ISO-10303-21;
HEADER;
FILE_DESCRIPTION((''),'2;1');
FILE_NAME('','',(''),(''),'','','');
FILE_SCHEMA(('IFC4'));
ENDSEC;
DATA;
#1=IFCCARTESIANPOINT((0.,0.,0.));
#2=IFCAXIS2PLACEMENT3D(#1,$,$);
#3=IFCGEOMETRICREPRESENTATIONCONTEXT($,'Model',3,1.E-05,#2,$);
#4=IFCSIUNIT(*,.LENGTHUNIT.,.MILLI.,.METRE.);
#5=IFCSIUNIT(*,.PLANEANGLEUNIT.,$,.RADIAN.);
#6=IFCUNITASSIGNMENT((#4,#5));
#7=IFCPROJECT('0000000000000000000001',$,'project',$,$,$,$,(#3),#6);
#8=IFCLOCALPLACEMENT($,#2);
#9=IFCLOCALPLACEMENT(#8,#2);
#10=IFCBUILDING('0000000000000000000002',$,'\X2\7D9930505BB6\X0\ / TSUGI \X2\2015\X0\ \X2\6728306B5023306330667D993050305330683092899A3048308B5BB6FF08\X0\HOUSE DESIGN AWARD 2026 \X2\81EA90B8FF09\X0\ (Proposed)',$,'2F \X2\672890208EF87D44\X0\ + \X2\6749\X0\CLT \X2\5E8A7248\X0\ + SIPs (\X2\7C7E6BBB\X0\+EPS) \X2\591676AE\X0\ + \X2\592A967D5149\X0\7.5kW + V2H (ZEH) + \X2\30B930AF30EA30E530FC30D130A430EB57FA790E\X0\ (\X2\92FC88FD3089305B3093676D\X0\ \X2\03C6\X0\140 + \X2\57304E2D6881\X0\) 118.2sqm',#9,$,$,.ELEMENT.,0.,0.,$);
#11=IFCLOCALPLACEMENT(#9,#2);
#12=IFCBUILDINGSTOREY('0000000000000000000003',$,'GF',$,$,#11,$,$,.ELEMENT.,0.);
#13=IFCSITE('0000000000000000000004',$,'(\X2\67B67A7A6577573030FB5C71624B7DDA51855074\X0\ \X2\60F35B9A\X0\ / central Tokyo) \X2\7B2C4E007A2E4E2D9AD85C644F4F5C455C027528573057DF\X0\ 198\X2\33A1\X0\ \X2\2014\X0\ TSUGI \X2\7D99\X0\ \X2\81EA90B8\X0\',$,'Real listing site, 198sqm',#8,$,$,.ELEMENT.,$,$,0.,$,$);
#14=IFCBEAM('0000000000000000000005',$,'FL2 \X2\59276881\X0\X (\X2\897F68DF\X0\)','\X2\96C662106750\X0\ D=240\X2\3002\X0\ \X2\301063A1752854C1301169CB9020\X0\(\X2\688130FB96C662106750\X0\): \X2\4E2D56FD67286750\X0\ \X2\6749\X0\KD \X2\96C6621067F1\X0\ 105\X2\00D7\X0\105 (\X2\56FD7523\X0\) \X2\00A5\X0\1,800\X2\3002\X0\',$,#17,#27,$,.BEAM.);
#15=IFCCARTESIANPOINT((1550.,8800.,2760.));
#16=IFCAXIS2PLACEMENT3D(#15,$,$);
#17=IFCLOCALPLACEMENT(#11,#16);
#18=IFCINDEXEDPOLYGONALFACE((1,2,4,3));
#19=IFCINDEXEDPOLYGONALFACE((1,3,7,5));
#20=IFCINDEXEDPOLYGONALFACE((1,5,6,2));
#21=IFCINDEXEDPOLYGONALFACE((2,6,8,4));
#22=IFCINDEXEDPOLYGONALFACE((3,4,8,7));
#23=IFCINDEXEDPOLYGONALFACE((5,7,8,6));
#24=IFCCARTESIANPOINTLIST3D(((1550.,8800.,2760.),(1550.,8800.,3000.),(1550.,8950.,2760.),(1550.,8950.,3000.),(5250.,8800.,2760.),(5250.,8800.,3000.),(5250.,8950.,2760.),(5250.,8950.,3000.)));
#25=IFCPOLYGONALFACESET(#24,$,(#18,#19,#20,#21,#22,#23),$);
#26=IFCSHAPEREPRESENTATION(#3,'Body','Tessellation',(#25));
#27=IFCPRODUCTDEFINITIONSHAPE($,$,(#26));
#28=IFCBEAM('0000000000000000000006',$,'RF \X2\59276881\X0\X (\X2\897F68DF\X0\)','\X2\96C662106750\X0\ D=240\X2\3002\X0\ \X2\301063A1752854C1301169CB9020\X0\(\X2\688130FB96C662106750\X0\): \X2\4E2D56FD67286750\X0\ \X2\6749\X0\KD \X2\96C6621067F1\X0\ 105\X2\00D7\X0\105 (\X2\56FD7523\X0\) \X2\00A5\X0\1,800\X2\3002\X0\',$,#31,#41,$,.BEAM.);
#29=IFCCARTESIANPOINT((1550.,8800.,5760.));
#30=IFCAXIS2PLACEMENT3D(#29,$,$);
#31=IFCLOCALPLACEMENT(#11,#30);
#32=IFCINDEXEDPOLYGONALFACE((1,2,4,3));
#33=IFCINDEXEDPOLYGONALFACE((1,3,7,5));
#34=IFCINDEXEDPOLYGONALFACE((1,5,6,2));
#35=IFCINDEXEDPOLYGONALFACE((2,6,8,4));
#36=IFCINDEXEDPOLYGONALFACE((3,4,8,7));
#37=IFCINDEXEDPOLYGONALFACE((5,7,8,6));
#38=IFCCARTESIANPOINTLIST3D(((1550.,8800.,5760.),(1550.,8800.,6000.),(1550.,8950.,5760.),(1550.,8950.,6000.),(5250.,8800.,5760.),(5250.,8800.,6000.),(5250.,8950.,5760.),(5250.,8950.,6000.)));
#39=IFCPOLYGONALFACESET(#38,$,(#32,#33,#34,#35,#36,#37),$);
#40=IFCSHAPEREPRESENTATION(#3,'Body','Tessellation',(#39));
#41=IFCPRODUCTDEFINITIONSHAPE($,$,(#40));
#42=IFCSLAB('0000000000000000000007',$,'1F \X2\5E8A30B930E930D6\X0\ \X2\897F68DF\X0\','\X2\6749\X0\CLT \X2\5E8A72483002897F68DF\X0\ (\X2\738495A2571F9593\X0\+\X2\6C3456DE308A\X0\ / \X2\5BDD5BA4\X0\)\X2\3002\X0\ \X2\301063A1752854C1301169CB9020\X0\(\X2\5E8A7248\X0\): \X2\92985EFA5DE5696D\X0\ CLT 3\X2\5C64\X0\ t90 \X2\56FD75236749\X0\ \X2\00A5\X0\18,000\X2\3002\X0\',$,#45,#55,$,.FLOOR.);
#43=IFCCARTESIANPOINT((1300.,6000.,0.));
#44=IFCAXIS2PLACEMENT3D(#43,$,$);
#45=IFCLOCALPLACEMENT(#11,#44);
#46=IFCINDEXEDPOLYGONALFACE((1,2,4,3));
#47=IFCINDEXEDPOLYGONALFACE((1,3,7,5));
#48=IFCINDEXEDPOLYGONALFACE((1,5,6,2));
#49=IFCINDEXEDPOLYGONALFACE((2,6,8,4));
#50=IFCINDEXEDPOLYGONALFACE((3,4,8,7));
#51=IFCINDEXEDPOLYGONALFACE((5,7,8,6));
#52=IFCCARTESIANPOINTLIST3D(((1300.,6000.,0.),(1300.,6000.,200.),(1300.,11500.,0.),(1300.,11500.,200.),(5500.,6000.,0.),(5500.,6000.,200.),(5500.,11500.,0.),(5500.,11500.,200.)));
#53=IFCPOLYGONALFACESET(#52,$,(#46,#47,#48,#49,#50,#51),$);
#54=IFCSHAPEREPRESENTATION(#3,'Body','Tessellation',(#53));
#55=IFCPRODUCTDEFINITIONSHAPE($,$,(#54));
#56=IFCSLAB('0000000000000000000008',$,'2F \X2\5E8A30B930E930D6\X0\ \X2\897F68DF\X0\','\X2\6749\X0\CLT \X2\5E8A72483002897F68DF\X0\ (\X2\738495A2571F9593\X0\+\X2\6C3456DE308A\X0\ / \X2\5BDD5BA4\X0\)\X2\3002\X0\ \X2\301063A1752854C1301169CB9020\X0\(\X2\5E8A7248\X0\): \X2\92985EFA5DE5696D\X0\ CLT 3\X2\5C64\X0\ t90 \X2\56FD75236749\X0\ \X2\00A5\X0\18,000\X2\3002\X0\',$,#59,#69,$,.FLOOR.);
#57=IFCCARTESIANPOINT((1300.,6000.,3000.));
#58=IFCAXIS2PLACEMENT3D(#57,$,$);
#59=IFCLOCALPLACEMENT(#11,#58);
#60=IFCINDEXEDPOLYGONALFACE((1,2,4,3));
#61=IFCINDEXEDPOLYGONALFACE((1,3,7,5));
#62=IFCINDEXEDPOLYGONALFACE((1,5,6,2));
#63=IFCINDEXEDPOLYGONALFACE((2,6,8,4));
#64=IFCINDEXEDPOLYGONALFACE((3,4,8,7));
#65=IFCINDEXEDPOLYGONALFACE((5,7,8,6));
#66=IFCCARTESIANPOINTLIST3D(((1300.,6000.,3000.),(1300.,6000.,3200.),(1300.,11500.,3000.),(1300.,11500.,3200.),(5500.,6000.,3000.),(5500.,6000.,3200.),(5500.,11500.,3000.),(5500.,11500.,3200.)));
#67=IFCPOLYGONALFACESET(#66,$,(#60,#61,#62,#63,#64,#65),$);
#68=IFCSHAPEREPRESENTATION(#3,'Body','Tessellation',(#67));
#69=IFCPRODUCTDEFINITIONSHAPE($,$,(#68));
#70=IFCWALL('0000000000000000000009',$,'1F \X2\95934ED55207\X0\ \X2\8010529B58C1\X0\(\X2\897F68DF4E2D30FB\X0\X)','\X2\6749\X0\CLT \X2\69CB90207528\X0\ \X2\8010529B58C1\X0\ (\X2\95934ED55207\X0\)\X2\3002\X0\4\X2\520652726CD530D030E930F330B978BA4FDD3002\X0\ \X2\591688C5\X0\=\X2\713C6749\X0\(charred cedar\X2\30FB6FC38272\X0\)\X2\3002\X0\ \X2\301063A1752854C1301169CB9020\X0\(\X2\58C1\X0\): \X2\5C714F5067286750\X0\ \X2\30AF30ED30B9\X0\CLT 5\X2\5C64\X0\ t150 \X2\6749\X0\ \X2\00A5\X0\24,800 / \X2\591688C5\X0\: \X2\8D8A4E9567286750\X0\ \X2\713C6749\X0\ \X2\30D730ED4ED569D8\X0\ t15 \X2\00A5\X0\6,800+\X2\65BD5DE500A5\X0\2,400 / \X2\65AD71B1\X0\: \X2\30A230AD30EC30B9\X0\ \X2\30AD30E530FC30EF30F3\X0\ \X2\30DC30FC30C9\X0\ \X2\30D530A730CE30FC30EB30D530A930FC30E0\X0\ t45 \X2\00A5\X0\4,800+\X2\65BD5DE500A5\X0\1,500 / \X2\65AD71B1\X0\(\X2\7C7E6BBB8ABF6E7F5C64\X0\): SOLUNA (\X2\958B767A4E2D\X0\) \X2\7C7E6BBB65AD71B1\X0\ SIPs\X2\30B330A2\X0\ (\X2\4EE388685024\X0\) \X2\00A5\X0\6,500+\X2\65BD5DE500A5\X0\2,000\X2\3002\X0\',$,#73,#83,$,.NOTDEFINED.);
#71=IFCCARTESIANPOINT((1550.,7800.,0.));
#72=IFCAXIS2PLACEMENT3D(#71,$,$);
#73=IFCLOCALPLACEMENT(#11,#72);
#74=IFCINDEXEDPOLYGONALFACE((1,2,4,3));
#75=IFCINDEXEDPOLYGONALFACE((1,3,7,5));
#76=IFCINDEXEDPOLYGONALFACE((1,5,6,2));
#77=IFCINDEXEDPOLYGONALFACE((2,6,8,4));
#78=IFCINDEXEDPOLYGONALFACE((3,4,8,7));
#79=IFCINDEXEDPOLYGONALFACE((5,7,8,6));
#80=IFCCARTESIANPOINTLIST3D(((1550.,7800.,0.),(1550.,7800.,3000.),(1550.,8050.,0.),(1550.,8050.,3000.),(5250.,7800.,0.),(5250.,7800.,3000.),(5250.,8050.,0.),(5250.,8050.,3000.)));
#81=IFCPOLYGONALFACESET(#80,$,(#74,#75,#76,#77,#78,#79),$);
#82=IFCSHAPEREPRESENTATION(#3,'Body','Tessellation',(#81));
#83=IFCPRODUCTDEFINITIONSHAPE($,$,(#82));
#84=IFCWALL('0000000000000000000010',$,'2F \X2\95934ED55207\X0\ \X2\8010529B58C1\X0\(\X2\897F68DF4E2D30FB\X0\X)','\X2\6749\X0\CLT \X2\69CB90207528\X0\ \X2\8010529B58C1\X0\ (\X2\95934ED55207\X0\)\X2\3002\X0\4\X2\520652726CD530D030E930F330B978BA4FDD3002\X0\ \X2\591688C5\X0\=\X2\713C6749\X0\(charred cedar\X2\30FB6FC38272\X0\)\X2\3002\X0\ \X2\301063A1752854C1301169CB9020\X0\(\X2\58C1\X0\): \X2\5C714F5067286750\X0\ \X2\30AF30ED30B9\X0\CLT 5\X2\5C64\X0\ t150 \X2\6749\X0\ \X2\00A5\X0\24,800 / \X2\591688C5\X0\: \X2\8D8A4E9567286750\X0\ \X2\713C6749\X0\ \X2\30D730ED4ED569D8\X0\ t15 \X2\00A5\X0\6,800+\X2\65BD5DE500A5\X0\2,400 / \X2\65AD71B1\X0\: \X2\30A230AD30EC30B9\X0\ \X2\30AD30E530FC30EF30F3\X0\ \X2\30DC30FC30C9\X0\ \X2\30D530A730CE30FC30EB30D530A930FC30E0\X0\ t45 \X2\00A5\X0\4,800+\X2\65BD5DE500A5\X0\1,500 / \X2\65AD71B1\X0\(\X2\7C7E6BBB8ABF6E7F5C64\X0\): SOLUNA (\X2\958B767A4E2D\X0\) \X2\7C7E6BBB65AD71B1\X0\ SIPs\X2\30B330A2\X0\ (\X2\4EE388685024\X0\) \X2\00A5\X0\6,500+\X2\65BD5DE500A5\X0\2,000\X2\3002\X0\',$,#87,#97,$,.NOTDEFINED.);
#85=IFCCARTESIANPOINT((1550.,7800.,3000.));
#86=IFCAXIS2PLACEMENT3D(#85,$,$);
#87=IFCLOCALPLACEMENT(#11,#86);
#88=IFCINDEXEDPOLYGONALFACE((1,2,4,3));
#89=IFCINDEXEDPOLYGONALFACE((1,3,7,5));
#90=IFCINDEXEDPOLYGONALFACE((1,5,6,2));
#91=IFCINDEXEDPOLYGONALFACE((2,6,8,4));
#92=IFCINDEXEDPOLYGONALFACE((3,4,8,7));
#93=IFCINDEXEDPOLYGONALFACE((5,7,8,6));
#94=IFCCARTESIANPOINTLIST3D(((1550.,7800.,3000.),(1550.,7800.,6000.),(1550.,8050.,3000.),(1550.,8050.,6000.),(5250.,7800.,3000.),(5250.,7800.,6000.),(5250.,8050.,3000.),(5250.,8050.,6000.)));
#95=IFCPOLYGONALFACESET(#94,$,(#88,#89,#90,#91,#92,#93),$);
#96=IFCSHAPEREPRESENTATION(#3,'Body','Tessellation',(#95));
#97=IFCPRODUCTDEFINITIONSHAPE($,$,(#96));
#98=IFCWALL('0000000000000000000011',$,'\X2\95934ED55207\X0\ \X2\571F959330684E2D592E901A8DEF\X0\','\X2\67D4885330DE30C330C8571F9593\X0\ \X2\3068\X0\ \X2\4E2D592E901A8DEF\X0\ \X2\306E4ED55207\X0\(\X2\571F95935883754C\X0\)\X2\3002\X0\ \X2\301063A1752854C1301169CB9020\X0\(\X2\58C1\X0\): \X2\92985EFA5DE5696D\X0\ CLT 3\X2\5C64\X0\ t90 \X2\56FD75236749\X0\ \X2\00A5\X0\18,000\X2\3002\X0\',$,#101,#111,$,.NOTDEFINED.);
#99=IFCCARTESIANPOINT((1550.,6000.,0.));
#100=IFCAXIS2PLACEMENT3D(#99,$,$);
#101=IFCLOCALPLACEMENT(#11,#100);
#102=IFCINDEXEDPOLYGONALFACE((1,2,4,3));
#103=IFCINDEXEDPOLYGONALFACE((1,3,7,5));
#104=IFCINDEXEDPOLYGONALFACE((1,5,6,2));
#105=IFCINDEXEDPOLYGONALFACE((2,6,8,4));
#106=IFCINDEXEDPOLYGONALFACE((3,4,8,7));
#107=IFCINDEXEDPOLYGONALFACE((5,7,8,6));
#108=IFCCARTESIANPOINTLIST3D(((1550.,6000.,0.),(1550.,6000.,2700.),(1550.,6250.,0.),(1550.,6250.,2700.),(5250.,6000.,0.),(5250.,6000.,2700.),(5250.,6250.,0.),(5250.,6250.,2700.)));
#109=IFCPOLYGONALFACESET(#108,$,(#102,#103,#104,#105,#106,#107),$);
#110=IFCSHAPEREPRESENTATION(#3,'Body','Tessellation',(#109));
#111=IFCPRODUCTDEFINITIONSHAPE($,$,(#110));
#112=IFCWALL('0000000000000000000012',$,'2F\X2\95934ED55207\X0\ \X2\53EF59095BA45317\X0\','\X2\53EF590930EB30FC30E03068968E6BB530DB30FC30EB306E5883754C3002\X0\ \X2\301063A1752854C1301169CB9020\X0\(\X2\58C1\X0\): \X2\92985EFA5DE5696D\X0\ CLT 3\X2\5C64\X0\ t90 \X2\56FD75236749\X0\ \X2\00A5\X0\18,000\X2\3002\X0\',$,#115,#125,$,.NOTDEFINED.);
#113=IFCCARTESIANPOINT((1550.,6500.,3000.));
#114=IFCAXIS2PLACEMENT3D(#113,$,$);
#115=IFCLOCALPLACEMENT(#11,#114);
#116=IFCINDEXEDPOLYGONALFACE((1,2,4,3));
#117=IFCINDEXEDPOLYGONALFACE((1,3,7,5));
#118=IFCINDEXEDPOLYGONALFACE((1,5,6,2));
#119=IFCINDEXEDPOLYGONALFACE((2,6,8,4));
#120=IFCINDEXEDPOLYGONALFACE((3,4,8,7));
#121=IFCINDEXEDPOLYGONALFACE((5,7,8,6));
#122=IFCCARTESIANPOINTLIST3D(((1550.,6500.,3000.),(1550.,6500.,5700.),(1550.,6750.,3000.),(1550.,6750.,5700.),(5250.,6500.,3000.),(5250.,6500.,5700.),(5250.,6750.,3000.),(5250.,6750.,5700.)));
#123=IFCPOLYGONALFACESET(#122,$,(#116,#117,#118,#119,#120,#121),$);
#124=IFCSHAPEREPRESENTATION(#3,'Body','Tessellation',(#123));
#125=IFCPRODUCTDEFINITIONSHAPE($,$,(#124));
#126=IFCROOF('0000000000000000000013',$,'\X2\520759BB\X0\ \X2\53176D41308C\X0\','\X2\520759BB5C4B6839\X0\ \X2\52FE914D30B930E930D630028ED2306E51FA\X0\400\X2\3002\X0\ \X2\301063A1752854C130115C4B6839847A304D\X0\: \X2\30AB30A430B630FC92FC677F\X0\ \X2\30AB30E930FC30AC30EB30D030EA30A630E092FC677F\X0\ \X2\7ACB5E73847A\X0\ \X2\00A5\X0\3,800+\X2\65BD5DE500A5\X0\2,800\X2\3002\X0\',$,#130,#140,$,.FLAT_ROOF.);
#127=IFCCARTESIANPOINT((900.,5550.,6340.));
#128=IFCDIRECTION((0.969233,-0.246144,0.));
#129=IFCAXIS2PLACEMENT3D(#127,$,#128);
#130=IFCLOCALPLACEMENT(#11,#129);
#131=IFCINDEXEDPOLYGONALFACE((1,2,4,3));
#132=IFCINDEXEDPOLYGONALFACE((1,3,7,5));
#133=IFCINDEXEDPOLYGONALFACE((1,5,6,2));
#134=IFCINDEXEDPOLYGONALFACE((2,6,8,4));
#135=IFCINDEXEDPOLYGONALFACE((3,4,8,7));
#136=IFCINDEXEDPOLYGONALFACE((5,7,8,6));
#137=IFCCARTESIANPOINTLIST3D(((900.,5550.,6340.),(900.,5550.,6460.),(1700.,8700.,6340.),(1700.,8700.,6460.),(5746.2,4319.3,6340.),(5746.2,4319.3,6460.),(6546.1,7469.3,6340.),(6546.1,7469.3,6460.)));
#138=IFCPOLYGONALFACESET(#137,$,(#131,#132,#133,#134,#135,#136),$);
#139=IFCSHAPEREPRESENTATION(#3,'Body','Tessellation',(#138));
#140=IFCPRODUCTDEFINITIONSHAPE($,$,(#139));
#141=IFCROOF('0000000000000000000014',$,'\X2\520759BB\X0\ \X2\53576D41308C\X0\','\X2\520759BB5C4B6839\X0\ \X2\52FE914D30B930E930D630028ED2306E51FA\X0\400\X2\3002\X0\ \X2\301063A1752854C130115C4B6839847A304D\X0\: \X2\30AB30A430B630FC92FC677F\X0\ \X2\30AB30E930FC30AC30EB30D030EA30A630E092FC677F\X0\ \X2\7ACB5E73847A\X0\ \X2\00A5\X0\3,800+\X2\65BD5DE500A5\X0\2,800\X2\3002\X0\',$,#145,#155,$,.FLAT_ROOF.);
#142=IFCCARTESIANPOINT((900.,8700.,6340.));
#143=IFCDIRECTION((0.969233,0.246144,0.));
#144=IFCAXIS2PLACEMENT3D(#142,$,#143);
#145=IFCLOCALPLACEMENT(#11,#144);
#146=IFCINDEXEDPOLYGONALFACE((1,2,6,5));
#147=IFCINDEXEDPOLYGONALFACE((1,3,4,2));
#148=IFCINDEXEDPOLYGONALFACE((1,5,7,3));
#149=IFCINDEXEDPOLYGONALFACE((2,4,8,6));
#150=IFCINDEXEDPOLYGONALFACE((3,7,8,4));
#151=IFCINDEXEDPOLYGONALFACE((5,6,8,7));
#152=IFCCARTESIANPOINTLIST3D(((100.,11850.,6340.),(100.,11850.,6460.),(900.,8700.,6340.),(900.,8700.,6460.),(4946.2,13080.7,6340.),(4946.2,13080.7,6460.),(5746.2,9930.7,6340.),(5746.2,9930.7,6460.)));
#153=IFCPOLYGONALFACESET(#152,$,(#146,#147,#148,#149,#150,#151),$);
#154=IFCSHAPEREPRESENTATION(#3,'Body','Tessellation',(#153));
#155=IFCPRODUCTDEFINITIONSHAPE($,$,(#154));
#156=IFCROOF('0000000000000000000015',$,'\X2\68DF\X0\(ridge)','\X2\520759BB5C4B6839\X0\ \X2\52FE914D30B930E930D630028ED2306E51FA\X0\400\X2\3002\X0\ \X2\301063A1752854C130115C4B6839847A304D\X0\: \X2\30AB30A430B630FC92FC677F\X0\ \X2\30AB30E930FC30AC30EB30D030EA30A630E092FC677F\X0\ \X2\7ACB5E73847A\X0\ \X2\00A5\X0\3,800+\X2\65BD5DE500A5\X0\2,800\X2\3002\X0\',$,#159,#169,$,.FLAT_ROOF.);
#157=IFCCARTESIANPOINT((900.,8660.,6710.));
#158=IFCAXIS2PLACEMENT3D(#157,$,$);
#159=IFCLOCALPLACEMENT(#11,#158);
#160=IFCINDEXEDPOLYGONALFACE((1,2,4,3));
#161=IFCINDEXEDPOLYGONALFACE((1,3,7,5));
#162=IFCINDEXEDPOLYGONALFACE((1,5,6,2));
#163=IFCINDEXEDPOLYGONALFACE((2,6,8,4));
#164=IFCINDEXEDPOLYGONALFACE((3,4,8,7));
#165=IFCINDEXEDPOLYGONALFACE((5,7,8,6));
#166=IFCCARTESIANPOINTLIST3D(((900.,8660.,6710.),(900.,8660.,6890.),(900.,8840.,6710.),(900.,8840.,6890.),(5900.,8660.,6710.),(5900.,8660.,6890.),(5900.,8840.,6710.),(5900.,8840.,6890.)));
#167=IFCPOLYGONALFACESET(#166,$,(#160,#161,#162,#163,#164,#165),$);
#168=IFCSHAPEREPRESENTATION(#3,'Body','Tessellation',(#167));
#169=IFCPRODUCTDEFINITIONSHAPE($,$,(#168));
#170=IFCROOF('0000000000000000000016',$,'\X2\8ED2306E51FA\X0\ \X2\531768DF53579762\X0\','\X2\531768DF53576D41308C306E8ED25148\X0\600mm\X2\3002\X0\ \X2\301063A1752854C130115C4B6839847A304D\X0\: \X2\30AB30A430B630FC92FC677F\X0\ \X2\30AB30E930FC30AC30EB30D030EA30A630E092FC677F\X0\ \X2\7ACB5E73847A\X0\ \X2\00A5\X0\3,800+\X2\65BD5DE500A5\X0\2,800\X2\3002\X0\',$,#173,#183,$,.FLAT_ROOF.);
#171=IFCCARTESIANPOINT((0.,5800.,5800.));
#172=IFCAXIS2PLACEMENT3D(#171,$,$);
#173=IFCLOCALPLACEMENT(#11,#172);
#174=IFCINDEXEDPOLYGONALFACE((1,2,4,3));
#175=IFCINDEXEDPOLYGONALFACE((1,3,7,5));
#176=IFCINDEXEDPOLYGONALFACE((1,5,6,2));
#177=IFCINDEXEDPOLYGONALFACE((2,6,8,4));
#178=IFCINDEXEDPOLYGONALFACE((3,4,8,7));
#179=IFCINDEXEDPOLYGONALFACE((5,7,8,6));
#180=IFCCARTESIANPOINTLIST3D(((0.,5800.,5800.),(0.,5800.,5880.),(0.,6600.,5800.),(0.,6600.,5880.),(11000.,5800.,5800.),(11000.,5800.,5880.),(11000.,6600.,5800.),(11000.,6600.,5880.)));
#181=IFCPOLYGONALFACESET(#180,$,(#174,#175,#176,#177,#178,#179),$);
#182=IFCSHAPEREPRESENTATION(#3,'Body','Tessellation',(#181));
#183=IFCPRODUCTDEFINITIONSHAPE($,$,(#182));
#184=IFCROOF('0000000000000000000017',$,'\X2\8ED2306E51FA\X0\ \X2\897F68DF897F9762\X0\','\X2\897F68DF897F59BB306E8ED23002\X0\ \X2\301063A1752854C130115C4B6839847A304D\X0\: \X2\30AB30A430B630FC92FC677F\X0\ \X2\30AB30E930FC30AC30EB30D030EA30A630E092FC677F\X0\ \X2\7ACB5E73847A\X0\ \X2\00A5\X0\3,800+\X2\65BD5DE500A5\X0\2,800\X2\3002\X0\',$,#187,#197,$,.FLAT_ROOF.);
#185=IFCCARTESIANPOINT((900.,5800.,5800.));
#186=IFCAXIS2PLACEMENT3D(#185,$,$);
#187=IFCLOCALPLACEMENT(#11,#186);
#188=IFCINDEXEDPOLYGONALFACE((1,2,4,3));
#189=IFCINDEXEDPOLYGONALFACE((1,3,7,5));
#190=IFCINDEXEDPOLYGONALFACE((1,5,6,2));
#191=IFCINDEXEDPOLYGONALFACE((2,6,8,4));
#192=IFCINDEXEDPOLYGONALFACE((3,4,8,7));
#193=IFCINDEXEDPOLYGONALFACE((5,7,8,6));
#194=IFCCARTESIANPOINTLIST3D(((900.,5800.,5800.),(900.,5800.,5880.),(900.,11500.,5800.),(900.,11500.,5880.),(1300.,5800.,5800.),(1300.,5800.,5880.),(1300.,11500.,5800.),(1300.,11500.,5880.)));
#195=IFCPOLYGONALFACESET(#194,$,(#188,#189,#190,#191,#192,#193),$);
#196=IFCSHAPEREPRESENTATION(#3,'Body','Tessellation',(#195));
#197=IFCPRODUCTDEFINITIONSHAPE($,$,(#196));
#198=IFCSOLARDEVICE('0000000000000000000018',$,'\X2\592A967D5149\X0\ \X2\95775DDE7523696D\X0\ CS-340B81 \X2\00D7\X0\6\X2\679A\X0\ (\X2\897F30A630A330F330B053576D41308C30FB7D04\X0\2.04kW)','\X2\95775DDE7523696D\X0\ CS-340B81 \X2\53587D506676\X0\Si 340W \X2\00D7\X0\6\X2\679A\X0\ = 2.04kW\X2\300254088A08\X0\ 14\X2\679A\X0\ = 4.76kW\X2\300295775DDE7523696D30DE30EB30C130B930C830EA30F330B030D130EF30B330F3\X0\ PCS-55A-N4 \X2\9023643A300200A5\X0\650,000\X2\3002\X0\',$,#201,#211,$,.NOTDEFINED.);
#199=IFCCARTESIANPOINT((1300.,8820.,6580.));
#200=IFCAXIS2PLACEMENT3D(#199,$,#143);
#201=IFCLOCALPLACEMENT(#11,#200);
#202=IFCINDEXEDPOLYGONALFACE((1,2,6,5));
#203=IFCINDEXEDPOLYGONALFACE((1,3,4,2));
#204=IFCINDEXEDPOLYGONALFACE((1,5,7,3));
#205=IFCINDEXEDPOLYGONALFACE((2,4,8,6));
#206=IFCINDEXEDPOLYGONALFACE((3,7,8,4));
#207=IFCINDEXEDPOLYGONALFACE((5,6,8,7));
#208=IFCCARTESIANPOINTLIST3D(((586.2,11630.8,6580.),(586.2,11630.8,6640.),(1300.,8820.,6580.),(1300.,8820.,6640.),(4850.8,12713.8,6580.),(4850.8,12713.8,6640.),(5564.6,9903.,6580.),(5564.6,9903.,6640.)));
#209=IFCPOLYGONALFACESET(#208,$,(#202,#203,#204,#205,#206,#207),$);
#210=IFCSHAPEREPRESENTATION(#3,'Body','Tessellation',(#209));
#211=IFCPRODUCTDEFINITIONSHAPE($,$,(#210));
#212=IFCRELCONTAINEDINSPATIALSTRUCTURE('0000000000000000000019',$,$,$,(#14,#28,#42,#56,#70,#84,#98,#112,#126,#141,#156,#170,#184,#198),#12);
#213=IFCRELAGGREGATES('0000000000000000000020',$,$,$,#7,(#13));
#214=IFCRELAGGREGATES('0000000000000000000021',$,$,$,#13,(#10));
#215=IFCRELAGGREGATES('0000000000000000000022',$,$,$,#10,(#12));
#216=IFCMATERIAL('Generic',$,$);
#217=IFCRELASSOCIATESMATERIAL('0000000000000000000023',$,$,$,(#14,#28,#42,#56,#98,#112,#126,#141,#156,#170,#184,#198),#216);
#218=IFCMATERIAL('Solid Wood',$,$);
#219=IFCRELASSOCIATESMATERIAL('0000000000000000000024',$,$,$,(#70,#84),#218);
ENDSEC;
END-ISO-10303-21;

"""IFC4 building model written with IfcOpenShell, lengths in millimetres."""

from ifc_helpers import new_model, si_unit, frame, frame_2d, origin, place, context, project, spatial, rectangle, extrude, material, element, save


model = new_model("IFC4")

# Units and contexts
model_context = context("Model", 3, precision=1e-05, world=origin())
ifc_project = project(units=[si_unit("LENGTHUNIT", "METRE", prefix="MILLI"), si_unit("PLANEANGLEUNIT", "RADIAN")], contexts=[model_context])

# Site, building, storey
site_placement = place(None, origin())
site = spatial("IfcSite", under=ifc_project, at=site_placement, Name="(架空敷地・山手線内側 想定 / central Tokyo) 第一種中高層住居専用地域 198㎡ — TSUGI 継 自邸", ObjectType="Real listing site, 198sqm", CompositionType="ELEMENT", RefElevation=0.0)
building_placement = place(site_placement, origin())
building = spatial("IfcBuilding", under=site, at=building_placement, Name="継ぐ家 / TSUGI ― 木に倣って継ぐことを覚える家（HOUSE DESIGN AWARD 2026 自邸） (Proposed)", ObjectType="2F 木造軸組 + 杉CLT 床版 + SIPs (籾殻+EPS) 外皮 + 太陽光7.5kW + V2H (ZEH) + スクリューパイル基礎 (鋼製らせん杭 φ140 + 地中梁) 118.2sqm", CompositionType="ELEMENT", ElevationOfRefHeight=0.0, ElevationOfTerrain=0.0)
storey_placement = place(building_placement, origin())
storey = spatial("IfcBuildingStorey", under=building, at=storey_placement, Name="GF", CompositionType="ELEMENT", Elevation=0.0)

# Beams
ifc_material_1 = material(Name="Generic")
beam_1_placement = place(storey_placement, frame((1550.0, 8800.0, 2760.0)))
element("IfcBeam", 1, at=beam_1_placement, inside=storey, material=ifc_material_1, Name="FL2 大梁X (西棟)", Description="集成材 D=240。 【採用品】構造(梁・集成材): 中国木材 杉KD 集成柱 105×105 (国産) ¥1,800。", PredefinedType="BEAM", context=model_context, shape_type="SweptSolid", body=[
    extrude(rectangle(XDim=3700.0, YDim=150.0, at=frame_2d((1850.0, 75.0))), frame((1550.0, 8800.0, 2760.0)), (0.0, 0.0, 1.0), 240.0),
])
beam_2_placement = place(storey_placement, frame((1550.0, 8800.0, 5760.0)))
element("IfcBeam", 2, at=beam_2_placement, inside=storey, material=ifc_material_1, Name="RF 大梁X (西棟)", Description="集成材 D=240。 【採用品】構造(梁・集成材): 中国木材 杉KD 集成柱 105×105 (国産) ¥1,800。", PredefinedType="BEAM", context=model_context, shape_type="SweptSolid", body=[
    extrude(rectangle(XDim=3700.0, YDim=150.0, at=frame_2d((1850.0, 75.0))), frame((1550.0, 8800.0, 5760.0)), (0.0, 0.0, 1.0), 240.0),
])

# Slabs
slab_1_placement = place(storey_placement, frame((1300.0, 6000.0, 0.0)))
element("IfcSlab", 3, at=slab_1_placement, inside=storey, material=ifc_material_1, Name="1F 床スラブ 西棟", Description="杉CLT 床版。西棟 (玄関土間+水回り / 寝室)。 【採用品】構造(床版): 銘建工業 CLT 3層 t90 国産杉 ¥18,000。", PredefinedType="FLOOR", context=model_context, shape_type="SweptSolid", body=[
    extrude(rectangle(XDim=4200.0, YDim=5500.0, at=frame_2d((2100.0, 2750.0))), frame((1300.0, 6000.0, 0.0)), (0.0, 0.0, 1.0), 200.0),
])
slab_2_placement = place(storey_placement, frame((1300.0, 6000.0, 3000.0)))
element("IfcSlab", 4, at=slab_2_placement, inside=storey, material=ifc_material_1, Name="2F 床スラブ 西棟", Description="杉CLT 床版。西棟 (玄関土間+水回り / 寝室)。 【採用品】構造(床版): 銘建工業 CLT 3層 t90 国産杉 ¥18,000。", PredefinedType="FLOOR", context=model_context, shape_type="SweptSolid", body=[
    extrude(rectangle(XDim=4200.0, YDim=5500.0, at=frame_2d((2100.0, 2750.0))), frame((1300.0, 6000.0, 3000.0)), (0.0, 0.0, 1.0), 200.0),
])

# Walls
ifc_material_2 = material(Name="Solid Wood")
wall_1_placement = place(storey_placement, frame((1550.0, 7800.0, 0.0)))
element("IfcWall", 5, at=wall_1_placement, inside=storey, material=ifc_material_2, Name="1F 間仕切 耐力壁(西棟中・X)", Description="杉CLT 構造用 耐力壁 (間仕切)。4分割法バランス確保。 外装=焼杉(charred cedar・濃色)。 【採用品】構造(壁): 山佐木材 クロスCLT 5層 t150 杉 ¥24,800 / 外装: 越井木材 焼杉 プロ仕様 t15 ¥6,800+施工¥2,400 / 断熱: アキレス キューワン ボード フェノールフォーム t45 ¥4,800+施工¥1,500 / 断熱(籾殻調湿層): SOLUNA (開発中) 籾殻断熱 SIPsコア (代表値) ¥6,500+施工¥2,000。", PredefinedType="NOTDEFINED", context=model_context, shape_type="SweptSolid", body=[
    extrude(rectangle(XDim=3700.0, YDim=250.0, at=frame_2d((1850.0, 125.0))), frame((1550.0, 7800.0, 0.0)), (0.0, 0.0, 1.0), 3000.0),
])
wall_2_placement = place(storey_placement, frame((1550.0, 7800.0, 3000.0)))
element("IfcWall", 6, at=wall_2_placement, inside=storey, material=ifc_material_2, Name="2F 間仕切 耐力壁(西棟中・X)", Description="杉CLT 構造用 耐力壁 (間仕切)。4分割法バランス確保。 外装=焼杉(charred cedar・濃色)。 【採用品】構造(壁): 山佐木材 クロスCLT 5層 t150 杉 ¥24,800 / 外装: 越井木材 焼杉 プロ仕様 t15 ¥6,800+施工¥2,400 / 断熱: アキレス キューワン ボード フェノールフォーム t45 ¥4,800+施工¥1,500 / 断熱(籾殻調湿層): SOLUNA (開発中) 籾殻断熱 SIPsコア (代表値) ¥6,500+施工¥2,000。", PredefinedType="NOTDEFINED", context=model_context, shape_type="SweptSolid", body=[
    extrude(rectangle(XDim=3700.0, YDim=250.0, at=frame_2d((1850.0, 125.0))), frame((1550.0, 7800.0, 3000.0)), (0.0, 0.0, 1.0), 3000.0),
])
wall_3_placement = place(storey_placement, frame((1550.0, 6000.0, 0.0)))
element("IfcWall", 7, at=wall_3_placement, inside=storey, material=ifc_material_1, Name="間仕切 土間と中央通路", Description="柔術マット土間 と 中央通路 の仕切(土間境界)。 【採用品】構造(壁): 銘建工業 CLT 3層 t90 国産杉 ¥18,000。", PredefinedType="NOTDEFINED", context=model_context, shape_type="SweptSolid", body=[
    extrude(rectangle(XDim=3700.0, YDim=250.0, at=frame_2d((1850.0, 125.0))), frame((1550.0, 6000.0, 0.0)), (0.0, 0.0, 1.0), 2700.0),
])
wall_4_placement = place(storey_placement, frame((1550.0, 6500.0, 3000.0)))
element("IfcWall", 8, at=wall_4_placement, inside=storey, material=ifc_material_1, Name="2F間仕切 可変室北", Description="可変ルームと階段ホールの境界。 【採用品】構造(壁): 銘建工業 CLT 3層 t90 国産杉 ¥18,000。", PredefinedType="NOTDEFINED", context=model_context, shape_type="SweptSolid", body=[
    extrude(rectangle(XDim=3700.0, YDim=250.0, at=frame_2d((1850.0, 125.0))), frame((1550.0, 6500.0, 3000.0)), (0.0, 0.0, 1.0), 2700.0),
])

# Roofs
roof_1_placement = place(storey_placement, frame((900.0, 5550.0, 6340.0), x_axis=(0.969233, -0.246144, 0.0)))
element("IfcRoof", 9, at=roof_1_placement, inside=storey, material=ifc_material_1, Name="切妻 北流れ", Description="切妻屋根 勾配スラブ。軒の出400。 【採用品】屋根葺き: カイザー鋼板 カラーガルバリウム鋼板 立平葺 ¥3,800+施工¥2,800。", PredefinedType="FLAT_ROOF", context=model_context, shape_type="SweptSolid", body=[
    extrude(rectangle(XDim=5000.0, YDim=3250.0, at=frame_2d((2500.0, 1625.0))), frame((900.0, 5550.0, 6340.0), x_axis=(0.969233, -0.246144, 0.0)), (0.0, 0.0, 1.0), 120.0),
])
roof_2_placement = place(storey_placement, frame((900.0, 8700.0, 6340.0), x_axis=(0.969233, 0.246144, 0.0)))
element("IfcRoof", 10, at=roof_2_placement, inside=storey, material=ifc_material_1, Name="切妻 南流れ", Description="切妻屋根 勾配スラブ。軒の出400。 【採用品】屋根葺き: カイザー鋼板 カラーガルバリウム鋼板 立平葺 ¥3,800+施工¥2,800。", PredefinedType="FLAT_ROOF", context=model_context, shape_type="SweptSolid", body=[
    extrude(rectangle(XDim=5000.0, YDim=3250.0, at=frame_2d((2500.0, 1625.0))), frame((900.0, 8700.0, 6340.0), x_axis=(0.969233, 0.246144, 0.0)), (0.0, 0.0, 1.0), 120.0),
])
roof_3_placement = place(storey_placement, frame((900.0, 8660.0, 6710.0)))
element("IfcRoof", 11, at=roof_3_placement, inside=storey, material=ifc_material_1, Name="棟(ridge)", Description="切妻屋根 勾配スラブ。軒の出400。 【採用品】屋根葺き: カイザー鋼板 カラーガルバリウム鋼板 立平葺 ¥3,800+施工¥2,800。", PredefinedType="FLAT_ROOF", context=model_context, shape_type="SweptSolid", body=[
    extrude(rectangle(XDim=5000.0, YDim=180.0, at=frame_2d((2500.0, 90.0))), frame((900.0, 8660.0, 6710.0)), (0.0, 0.0, 1.0), 180.0),
])
roof_4_placement = place(storey_placement, frame((0.0, 5800.0, 5800.0)))
element("IfcRoof", 12, at=roof_4_placement, inside=storey, material=ifc_material_1, Name="軒の出 北棟南面", Description="北棟南流れの軒先600mm。 【採用品】屋根葺き: カイザー鋼板 カラーガルバリウム鋼板 立平葺 ¥3,800+施工¥2,800。", PredefinedType="FLAT_ROOF", context=model_context, shape_type="SweptSolid", body=[
    extrude(rectangle(XDim=11000.0, YDim=800.0, at=frame_2d((5500.0, 400.0))), frame((0.0, 5800.0, 5800.0)), (0.0, 0.0, 1.0), 80.0),
])
roof_5_placement = place(storey_placement, frame((900.0, 5800.0, 5800.0)))
element("IfcRoof", 13, at=roof_5_placement, inside=storey, material=ifc_material_1, Name="軒の出 西棟西面", Description="西棟西妻の軒。 【採用品】屋根葺き: カイザー鋼板 カラーガルバリウム鋼板 立平葺 ¥3,800+施工¥2,800。", PredefinedType="FLAT_ROOF", context=model_context, shape_type="SweptSolid", body=[
    extrude(rectangle(XDim=400.0, YDim=5700.0, at=frame_2d((200.0, 2850.0))), frame((900.0, 5800.0, 5800.0)), (0.0, 0.0, 1.0), 80.0),
])

# Solar device
solar_device_placement = place(storey_placement, frame((1300.0, 8820.0, 6580.0), x_axis=(0.969233, 0.246144, 0.0)))
element("IfcSolarDevice", 14, at=solar_device_placement, inside=storey, material=ifc_material_1, Name="太陽光 長州産業 CS-340B81 ×6枚 (西ウィング南流れ・約2.04kW)", Description="長州産業 CS-340B81 単結晶Si 340W ×6枚 = 2.04kW。合計 14枚 = 4.76kW。長州産業マルチストリングパワコン PCS-55A-N4 連携。¥650,000。", PredefinedType="NOTDEFINED", context=model_context, shape_type="SweptSolid", body=[
    extrude(rectangle(XDim=4400.0, YDim=2900.0, at=frame_2d((2200.0, 1450.0))), frame((1300.0, 8820.0, 6580.0), x_axis=(0.969233, 0.246144, 0.0)), (0.0, 0.0, 1.0), 60.0),
])

save(model, "model.ifc")
